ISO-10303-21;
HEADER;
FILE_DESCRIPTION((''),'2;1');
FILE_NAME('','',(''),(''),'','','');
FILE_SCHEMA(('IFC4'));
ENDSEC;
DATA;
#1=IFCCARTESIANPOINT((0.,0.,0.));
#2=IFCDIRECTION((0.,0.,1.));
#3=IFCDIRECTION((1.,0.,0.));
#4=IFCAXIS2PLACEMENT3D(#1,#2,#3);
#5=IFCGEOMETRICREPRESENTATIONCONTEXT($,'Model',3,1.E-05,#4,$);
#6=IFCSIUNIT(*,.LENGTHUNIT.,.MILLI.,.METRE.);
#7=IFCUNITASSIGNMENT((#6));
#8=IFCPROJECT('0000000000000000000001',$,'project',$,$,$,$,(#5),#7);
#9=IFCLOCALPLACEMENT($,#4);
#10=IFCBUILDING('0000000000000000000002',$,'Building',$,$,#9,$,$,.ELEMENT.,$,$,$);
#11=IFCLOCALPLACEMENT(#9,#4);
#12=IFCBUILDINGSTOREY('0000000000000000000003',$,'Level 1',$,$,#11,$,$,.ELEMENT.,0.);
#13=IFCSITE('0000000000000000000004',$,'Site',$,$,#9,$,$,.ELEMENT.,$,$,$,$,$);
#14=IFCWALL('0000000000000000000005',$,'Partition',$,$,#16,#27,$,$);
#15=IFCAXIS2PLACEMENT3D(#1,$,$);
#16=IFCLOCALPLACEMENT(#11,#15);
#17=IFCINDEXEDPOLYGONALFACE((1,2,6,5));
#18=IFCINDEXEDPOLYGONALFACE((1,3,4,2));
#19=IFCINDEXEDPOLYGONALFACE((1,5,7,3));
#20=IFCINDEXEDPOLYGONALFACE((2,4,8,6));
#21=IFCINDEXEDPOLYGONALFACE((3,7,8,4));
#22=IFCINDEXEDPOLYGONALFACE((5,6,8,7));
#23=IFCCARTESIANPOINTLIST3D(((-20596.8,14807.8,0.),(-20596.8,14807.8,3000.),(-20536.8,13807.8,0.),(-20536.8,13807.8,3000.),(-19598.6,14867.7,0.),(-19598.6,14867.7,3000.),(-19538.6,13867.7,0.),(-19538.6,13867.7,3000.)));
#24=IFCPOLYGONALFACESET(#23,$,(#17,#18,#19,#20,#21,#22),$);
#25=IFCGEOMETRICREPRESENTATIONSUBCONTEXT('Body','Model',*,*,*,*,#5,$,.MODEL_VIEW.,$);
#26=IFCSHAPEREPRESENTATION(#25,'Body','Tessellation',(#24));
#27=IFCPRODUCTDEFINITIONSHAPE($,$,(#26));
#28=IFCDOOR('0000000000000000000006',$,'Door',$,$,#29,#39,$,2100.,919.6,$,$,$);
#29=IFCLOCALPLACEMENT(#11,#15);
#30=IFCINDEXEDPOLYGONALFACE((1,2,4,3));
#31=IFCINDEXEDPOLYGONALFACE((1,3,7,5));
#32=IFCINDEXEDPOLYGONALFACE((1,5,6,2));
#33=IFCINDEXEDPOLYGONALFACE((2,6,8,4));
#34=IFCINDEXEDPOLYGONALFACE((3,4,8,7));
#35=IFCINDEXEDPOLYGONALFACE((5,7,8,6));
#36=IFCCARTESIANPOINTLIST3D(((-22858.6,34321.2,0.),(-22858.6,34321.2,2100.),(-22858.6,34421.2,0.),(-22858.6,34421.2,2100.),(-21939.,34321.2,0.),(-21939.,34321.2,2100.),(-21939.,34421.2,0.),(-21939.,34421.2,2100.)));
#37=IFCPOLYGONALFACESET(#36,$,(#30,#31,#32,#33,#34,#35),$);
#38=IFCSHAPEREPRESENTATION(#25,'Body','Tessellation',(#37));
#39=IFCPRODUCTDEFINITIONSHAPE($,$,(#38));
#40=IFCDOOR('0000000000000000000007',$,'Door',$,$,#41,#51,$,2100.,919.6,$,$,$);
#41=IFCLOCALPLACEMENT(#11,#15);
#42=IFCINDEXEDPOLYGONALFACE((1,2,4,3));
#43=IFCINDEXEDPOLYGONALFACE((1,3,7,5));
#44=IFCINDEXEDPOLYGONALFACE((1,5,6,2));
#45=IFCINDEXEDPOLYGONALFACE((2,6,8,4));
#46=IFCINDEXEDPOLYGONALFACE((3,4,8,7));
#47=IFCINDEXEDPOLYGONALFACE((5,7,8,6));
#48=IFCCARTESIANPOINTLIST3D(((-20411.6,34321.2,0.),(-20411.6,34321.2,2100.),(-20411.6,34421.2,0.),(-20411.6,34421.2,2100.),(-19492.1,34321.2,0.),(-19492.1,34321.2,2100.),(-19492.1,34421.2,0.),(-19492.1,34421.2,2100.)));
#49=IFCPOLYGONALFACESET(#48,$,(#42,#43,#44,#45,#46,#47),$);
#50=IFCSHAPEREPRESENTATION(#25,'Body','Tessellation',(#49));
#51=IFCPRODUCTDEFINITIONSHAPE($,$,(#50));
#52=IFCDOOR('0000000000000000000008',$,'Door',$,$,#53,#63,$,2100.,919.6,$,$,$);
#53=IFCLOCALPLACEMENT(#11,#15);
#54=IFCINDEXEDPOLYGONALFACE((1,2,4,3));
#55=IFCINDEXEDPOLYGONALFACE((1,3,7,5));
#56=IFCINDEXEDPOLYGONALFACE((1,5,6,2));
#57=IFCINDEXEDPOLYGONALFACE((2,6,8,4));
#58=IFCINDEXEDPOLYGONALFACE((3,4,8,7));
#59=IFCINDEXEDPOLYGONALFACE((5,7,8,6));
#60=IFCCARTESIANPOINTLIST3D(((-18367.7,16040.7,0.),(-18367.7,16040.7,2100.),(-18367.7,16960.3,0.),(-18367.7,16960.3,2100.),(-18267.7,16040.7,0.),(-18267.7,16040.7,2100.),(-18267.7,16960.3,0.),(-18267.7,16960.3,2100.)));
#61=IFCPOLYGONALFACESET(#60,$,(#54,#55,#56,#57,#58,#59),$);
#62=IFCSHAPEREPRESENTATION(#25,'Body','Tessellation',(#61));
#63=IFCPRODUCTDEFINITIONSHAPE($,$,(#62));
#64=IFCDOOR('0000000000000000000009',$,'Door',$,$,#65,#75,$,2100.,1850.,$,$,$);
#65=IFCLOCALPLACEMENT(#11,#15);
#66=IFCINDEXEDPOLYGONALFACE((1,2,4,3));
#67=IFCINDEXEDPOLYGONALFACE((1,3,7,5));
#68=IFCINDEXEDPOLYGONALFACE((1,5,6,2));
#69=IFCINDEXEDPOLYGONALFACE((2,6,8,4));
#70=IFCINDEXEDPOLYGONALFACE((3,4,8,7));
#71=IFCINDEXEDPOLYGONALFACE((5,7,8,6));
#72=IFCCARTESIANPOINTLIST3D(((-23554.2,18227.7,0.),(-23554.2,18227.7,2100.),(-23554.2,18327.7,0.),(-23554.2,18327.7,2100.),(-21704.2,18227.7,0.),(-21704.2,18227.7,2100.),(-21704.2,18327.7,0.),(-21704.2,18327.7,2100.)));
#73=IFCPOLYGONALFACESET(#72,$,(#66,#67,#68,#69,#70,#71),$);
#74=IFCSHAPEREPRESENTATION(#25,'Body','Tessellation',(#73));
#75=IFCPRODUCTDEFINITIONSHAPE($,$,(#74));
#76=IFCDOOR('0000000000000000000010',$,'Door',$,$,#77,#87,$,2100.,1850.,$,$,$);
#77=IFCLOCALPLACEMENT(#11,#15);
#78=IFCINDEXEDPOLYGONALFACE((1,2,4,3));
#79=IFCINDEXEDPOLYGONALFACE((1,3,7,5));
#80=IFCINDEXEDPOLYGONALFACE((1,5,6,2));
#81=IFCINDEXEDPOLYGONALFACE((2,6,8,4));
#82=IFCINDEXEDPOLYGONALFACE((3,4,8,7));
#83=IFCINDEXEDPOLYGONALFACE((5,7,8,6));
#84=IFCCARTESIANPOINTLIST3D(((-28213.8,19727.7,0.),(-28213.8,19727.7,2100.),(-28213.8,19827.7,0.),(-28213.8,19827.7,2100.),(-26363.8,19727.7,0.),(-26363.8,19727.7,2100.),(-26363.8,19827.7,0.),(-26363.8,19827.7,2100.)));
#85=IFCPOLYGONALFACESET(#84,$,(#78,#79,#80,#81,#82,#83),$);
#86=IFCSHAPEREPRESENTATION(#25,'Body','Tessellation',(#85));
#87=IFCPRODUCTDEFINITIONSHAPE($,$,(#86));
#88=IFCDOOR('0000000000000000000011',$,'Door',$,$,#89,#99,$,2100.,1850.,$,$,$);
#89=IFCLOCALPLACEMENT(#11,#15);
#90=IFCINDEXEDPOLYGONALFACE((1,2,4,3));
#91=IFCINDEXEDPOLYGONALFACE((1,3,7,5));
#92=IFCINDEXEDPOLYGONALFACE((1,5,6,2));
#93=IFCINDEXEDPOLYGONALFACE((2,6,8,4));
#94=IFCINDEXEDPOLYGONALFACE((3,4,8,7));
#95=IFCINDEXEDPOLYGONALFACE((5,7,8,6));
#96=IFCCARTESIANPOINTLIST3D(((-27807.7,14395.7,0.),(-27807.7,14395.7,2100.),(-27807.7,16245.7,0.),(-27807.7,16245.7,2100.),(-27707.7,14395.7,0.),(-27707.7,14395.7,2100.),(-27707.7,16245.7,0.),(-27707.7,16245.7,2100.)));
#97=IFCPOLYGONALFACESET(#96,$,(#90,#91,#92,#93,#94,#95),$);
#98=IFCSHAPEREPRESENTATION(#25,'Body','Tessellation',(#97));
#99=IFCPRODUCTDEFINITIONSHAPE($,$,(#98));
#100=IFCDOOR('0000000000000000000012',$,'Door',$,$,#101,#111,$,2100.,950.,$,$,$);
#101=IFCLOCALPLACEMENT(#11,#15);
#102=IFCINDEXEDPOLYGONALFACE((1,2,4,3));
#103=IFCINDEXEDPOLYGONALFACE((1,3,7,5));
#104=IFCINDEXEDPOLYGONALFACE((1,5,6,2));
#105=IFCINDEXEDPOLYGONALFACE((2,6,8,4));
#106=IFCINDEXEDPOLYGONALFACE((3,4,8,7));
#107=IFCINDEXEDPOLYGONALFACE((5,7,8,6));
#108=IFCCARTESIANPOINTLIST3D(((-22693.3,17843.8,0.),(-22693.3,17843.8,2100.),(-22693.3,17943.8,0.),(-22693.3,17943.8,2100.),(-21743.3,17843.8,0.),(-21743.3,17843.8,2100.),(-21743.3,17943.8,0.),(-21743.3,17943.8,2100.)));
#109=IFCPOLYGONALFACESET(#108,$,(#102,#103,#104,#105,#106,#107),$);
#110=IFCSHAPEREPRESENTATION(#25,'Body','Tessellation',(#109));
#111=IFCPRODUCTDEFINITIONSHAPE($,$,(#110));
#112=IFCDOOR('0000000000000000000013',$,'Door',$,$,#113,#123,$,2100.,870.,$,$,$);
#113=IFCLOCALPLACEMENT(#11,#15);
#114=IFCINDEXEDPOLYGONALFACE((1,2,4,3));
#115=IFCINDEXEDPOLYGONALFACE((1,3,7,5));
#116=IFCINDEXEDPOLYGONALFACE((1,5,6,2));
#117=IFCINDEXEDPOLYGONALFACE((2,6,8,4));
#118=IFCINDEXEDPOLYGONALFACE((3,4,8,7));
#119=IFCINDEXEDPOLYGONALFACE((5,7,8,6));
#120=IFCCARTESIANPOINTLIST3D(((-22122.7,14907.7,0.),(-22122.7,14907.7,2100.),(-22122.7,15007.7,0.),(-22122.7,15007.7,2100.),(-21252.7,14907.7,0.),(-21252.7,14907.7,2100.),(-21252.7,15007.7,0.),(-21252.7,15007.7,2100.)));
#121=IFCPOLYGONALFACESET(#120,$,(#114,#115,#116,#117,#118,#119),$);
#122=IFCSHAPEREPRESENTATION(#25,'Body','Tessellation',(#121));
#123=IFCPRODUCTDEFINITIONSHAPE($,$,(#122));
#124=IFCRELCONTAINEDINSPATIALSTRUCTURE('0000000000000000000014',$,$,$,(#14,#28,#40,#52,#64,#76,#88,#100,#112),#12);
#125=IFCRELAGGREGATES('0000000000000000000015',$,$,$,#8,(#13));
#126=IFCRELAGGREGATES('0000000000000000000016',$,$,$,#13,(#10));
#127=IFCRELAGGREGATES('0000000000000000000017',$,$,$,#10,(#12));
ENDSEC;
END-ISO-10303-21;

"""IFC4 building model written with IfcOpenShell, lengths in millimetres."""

from ifc_helpers import new_model, si_unit, frame, frame_2d, origin_with_axes, place, context, subcontext, project, spatial, rectangle, extrude, element, save


model = new_model("IFC4")

# Units and contexts
model_context = context("Model", 3, precision=1e-05, world=origin_with_axes())
body_context = subcontext(model_context, "Body", "Model", "MODEL_VIEW")
ifc_project = project(units=[si_unit("LENGTHUNIT", "METRE", prefix="MILLI")], contexts=[model_context])

# Site, building, storey
placement = place(None, origin_with_axes())
site = spatial("IfcSite", under=ifc_project, at=placement, Name="Site", CompositionType="ELEMENT")
building = spatial("IfcBuilding", under=site, at=placement, Name="Building", CompositionType="ELEMENT")
storey_placement = place(placement, origin_with_axes())
storey = spatial("IfcBuildingStorey", under=building, at=storey_placement, Name="Level 1", CompositionType="ELEMENT", Elevation=0.0)

# Wall
wall_1_placement = place(placement, frame((-20097.7, 14837.7, 0.0), z_axis=(0.0, 0.0, 1.0), x_axis=(0.059892, -0.998205, 0.0)))
element("IfcWall", 1, at=wall_1_placement, inside=storey, Name="Partition", context=body_context, shape_type="SweptSolid", body=[
    extrude(rectangle(XDim=1001.8, YDim=1000.0, at=frame_2d((500.9, 0.0), x_axis=(1.0, 0.0))), origin_with_axes(), (0.0, 0.0, 1.0), 3000.0),
])

# Doors
for number, where, z_axis, x_axis, name in (
    (2, (-22858.6, 34371.2, 0.0), (0.0, 0.0, 1.0), (1.0, 0.0, 0.0), "Door"),
    (3, (-20411.6, 34371.2, 0.0), (0.0, 0.0, 1.0), (1.0, 0.0, 0.0), "Door"),
    (4, (-18317.7, 16040.7, 0.0), (0.0, 0.0, 1.0), (0.0, 1.0, 0.0), "Door"),
):
    element("IfcDoor", number, at=place(placement, frame(where, z_axis=z_axis, x_axis=x_axis)), inside=storey, Name=name, OverallHeight=2100.0, OverallWidth=919.6, context=body_context, shape_type="SweptSolid", body=[
        extrude(rectangle(XDim=919.6, YDim=100.0, at=frame_2d((459.8, 0.0), x_axis=(1.0, 0.0))), origin_with_axes(), (0.0, 0.0, 1.0), 2100.0),
    ])
for number, where, z_axis, x_axis, name in (
    (5, (-21704.2, 18277.7, 0.0), (0.0, 0.0, 1.0), (-1.0, 0.0, 0.0), "Door"),
    (6, (-26363.8, 19777.7, 0.0), (0.0, 0.0, 1.0), (-1.0, 0.0, 0.0), "Door"),
    (7, (-27757.7, 16245.7, 0.0), (0.0, 0.0, 1.0), (0.0, -1.0, 0.0), "Door"),
):
    element("IfcDoor", number, at=place(placement, frame(where, z_axis=z_axis, x_axis=x_axis)), inside=storey, Name=name, OverallHeight=2100.0, OverallWidth=1850.0, context=body_context, shape_type="SweptSolid", body=[
        extrude(rectangle(XDim=1850.0, YDim=100.0, at=frame_2d((925.0, 0.0), x_axis=(1.0, 0.0))), origin_with_axes(), (0.0, 0.0, 1.0), 2100.0),
    ])
door_1_placement = place(placement, frame((-21743.3, 17893.8, 0.0), z_axis=(0.0, 0.0, 1.0), x_axis=(-1.0, 0.0, 0.0)))
element("IfcDoor", 8, at=door_1_placement, inside=storey, Name="Door", OverallHeight=2100.0, OverallWidth=950.0, context=body_context, shape_type="SweptSolid", body=[
    extrude(rectangle(XDim=950.0, YDim=100.0, at=frame_2d((475.0, 0.0), x_axis=(1.0, 0.0))), origin_with_axes(), (0.0, 0.0, 1.0), 2100.0),
])
door_2_placement = place(placement, frame((-22122.7, 14957.7, 0.0), z_axis=(0.0, 0.0, 1.0), x_axis=(1.0, 0.0, 0.0)))
element("IfcDoor", 9, at=door_2_placement, inside=storey, Name="Door", OverallHeight=2100.0, OverallWidth=870.0, context=body_context, shape_type="SweptSolid", body=[
    extrude(rectangle(XDim=870.0, YDim=100.0, at=frame_2d((435.0, 0.0), x_axis=(1.0, 0.0))), origin_with_axes(), (0.0, 0.0, 1.0), 2100.0),
])

save(model, "model.ifc")
